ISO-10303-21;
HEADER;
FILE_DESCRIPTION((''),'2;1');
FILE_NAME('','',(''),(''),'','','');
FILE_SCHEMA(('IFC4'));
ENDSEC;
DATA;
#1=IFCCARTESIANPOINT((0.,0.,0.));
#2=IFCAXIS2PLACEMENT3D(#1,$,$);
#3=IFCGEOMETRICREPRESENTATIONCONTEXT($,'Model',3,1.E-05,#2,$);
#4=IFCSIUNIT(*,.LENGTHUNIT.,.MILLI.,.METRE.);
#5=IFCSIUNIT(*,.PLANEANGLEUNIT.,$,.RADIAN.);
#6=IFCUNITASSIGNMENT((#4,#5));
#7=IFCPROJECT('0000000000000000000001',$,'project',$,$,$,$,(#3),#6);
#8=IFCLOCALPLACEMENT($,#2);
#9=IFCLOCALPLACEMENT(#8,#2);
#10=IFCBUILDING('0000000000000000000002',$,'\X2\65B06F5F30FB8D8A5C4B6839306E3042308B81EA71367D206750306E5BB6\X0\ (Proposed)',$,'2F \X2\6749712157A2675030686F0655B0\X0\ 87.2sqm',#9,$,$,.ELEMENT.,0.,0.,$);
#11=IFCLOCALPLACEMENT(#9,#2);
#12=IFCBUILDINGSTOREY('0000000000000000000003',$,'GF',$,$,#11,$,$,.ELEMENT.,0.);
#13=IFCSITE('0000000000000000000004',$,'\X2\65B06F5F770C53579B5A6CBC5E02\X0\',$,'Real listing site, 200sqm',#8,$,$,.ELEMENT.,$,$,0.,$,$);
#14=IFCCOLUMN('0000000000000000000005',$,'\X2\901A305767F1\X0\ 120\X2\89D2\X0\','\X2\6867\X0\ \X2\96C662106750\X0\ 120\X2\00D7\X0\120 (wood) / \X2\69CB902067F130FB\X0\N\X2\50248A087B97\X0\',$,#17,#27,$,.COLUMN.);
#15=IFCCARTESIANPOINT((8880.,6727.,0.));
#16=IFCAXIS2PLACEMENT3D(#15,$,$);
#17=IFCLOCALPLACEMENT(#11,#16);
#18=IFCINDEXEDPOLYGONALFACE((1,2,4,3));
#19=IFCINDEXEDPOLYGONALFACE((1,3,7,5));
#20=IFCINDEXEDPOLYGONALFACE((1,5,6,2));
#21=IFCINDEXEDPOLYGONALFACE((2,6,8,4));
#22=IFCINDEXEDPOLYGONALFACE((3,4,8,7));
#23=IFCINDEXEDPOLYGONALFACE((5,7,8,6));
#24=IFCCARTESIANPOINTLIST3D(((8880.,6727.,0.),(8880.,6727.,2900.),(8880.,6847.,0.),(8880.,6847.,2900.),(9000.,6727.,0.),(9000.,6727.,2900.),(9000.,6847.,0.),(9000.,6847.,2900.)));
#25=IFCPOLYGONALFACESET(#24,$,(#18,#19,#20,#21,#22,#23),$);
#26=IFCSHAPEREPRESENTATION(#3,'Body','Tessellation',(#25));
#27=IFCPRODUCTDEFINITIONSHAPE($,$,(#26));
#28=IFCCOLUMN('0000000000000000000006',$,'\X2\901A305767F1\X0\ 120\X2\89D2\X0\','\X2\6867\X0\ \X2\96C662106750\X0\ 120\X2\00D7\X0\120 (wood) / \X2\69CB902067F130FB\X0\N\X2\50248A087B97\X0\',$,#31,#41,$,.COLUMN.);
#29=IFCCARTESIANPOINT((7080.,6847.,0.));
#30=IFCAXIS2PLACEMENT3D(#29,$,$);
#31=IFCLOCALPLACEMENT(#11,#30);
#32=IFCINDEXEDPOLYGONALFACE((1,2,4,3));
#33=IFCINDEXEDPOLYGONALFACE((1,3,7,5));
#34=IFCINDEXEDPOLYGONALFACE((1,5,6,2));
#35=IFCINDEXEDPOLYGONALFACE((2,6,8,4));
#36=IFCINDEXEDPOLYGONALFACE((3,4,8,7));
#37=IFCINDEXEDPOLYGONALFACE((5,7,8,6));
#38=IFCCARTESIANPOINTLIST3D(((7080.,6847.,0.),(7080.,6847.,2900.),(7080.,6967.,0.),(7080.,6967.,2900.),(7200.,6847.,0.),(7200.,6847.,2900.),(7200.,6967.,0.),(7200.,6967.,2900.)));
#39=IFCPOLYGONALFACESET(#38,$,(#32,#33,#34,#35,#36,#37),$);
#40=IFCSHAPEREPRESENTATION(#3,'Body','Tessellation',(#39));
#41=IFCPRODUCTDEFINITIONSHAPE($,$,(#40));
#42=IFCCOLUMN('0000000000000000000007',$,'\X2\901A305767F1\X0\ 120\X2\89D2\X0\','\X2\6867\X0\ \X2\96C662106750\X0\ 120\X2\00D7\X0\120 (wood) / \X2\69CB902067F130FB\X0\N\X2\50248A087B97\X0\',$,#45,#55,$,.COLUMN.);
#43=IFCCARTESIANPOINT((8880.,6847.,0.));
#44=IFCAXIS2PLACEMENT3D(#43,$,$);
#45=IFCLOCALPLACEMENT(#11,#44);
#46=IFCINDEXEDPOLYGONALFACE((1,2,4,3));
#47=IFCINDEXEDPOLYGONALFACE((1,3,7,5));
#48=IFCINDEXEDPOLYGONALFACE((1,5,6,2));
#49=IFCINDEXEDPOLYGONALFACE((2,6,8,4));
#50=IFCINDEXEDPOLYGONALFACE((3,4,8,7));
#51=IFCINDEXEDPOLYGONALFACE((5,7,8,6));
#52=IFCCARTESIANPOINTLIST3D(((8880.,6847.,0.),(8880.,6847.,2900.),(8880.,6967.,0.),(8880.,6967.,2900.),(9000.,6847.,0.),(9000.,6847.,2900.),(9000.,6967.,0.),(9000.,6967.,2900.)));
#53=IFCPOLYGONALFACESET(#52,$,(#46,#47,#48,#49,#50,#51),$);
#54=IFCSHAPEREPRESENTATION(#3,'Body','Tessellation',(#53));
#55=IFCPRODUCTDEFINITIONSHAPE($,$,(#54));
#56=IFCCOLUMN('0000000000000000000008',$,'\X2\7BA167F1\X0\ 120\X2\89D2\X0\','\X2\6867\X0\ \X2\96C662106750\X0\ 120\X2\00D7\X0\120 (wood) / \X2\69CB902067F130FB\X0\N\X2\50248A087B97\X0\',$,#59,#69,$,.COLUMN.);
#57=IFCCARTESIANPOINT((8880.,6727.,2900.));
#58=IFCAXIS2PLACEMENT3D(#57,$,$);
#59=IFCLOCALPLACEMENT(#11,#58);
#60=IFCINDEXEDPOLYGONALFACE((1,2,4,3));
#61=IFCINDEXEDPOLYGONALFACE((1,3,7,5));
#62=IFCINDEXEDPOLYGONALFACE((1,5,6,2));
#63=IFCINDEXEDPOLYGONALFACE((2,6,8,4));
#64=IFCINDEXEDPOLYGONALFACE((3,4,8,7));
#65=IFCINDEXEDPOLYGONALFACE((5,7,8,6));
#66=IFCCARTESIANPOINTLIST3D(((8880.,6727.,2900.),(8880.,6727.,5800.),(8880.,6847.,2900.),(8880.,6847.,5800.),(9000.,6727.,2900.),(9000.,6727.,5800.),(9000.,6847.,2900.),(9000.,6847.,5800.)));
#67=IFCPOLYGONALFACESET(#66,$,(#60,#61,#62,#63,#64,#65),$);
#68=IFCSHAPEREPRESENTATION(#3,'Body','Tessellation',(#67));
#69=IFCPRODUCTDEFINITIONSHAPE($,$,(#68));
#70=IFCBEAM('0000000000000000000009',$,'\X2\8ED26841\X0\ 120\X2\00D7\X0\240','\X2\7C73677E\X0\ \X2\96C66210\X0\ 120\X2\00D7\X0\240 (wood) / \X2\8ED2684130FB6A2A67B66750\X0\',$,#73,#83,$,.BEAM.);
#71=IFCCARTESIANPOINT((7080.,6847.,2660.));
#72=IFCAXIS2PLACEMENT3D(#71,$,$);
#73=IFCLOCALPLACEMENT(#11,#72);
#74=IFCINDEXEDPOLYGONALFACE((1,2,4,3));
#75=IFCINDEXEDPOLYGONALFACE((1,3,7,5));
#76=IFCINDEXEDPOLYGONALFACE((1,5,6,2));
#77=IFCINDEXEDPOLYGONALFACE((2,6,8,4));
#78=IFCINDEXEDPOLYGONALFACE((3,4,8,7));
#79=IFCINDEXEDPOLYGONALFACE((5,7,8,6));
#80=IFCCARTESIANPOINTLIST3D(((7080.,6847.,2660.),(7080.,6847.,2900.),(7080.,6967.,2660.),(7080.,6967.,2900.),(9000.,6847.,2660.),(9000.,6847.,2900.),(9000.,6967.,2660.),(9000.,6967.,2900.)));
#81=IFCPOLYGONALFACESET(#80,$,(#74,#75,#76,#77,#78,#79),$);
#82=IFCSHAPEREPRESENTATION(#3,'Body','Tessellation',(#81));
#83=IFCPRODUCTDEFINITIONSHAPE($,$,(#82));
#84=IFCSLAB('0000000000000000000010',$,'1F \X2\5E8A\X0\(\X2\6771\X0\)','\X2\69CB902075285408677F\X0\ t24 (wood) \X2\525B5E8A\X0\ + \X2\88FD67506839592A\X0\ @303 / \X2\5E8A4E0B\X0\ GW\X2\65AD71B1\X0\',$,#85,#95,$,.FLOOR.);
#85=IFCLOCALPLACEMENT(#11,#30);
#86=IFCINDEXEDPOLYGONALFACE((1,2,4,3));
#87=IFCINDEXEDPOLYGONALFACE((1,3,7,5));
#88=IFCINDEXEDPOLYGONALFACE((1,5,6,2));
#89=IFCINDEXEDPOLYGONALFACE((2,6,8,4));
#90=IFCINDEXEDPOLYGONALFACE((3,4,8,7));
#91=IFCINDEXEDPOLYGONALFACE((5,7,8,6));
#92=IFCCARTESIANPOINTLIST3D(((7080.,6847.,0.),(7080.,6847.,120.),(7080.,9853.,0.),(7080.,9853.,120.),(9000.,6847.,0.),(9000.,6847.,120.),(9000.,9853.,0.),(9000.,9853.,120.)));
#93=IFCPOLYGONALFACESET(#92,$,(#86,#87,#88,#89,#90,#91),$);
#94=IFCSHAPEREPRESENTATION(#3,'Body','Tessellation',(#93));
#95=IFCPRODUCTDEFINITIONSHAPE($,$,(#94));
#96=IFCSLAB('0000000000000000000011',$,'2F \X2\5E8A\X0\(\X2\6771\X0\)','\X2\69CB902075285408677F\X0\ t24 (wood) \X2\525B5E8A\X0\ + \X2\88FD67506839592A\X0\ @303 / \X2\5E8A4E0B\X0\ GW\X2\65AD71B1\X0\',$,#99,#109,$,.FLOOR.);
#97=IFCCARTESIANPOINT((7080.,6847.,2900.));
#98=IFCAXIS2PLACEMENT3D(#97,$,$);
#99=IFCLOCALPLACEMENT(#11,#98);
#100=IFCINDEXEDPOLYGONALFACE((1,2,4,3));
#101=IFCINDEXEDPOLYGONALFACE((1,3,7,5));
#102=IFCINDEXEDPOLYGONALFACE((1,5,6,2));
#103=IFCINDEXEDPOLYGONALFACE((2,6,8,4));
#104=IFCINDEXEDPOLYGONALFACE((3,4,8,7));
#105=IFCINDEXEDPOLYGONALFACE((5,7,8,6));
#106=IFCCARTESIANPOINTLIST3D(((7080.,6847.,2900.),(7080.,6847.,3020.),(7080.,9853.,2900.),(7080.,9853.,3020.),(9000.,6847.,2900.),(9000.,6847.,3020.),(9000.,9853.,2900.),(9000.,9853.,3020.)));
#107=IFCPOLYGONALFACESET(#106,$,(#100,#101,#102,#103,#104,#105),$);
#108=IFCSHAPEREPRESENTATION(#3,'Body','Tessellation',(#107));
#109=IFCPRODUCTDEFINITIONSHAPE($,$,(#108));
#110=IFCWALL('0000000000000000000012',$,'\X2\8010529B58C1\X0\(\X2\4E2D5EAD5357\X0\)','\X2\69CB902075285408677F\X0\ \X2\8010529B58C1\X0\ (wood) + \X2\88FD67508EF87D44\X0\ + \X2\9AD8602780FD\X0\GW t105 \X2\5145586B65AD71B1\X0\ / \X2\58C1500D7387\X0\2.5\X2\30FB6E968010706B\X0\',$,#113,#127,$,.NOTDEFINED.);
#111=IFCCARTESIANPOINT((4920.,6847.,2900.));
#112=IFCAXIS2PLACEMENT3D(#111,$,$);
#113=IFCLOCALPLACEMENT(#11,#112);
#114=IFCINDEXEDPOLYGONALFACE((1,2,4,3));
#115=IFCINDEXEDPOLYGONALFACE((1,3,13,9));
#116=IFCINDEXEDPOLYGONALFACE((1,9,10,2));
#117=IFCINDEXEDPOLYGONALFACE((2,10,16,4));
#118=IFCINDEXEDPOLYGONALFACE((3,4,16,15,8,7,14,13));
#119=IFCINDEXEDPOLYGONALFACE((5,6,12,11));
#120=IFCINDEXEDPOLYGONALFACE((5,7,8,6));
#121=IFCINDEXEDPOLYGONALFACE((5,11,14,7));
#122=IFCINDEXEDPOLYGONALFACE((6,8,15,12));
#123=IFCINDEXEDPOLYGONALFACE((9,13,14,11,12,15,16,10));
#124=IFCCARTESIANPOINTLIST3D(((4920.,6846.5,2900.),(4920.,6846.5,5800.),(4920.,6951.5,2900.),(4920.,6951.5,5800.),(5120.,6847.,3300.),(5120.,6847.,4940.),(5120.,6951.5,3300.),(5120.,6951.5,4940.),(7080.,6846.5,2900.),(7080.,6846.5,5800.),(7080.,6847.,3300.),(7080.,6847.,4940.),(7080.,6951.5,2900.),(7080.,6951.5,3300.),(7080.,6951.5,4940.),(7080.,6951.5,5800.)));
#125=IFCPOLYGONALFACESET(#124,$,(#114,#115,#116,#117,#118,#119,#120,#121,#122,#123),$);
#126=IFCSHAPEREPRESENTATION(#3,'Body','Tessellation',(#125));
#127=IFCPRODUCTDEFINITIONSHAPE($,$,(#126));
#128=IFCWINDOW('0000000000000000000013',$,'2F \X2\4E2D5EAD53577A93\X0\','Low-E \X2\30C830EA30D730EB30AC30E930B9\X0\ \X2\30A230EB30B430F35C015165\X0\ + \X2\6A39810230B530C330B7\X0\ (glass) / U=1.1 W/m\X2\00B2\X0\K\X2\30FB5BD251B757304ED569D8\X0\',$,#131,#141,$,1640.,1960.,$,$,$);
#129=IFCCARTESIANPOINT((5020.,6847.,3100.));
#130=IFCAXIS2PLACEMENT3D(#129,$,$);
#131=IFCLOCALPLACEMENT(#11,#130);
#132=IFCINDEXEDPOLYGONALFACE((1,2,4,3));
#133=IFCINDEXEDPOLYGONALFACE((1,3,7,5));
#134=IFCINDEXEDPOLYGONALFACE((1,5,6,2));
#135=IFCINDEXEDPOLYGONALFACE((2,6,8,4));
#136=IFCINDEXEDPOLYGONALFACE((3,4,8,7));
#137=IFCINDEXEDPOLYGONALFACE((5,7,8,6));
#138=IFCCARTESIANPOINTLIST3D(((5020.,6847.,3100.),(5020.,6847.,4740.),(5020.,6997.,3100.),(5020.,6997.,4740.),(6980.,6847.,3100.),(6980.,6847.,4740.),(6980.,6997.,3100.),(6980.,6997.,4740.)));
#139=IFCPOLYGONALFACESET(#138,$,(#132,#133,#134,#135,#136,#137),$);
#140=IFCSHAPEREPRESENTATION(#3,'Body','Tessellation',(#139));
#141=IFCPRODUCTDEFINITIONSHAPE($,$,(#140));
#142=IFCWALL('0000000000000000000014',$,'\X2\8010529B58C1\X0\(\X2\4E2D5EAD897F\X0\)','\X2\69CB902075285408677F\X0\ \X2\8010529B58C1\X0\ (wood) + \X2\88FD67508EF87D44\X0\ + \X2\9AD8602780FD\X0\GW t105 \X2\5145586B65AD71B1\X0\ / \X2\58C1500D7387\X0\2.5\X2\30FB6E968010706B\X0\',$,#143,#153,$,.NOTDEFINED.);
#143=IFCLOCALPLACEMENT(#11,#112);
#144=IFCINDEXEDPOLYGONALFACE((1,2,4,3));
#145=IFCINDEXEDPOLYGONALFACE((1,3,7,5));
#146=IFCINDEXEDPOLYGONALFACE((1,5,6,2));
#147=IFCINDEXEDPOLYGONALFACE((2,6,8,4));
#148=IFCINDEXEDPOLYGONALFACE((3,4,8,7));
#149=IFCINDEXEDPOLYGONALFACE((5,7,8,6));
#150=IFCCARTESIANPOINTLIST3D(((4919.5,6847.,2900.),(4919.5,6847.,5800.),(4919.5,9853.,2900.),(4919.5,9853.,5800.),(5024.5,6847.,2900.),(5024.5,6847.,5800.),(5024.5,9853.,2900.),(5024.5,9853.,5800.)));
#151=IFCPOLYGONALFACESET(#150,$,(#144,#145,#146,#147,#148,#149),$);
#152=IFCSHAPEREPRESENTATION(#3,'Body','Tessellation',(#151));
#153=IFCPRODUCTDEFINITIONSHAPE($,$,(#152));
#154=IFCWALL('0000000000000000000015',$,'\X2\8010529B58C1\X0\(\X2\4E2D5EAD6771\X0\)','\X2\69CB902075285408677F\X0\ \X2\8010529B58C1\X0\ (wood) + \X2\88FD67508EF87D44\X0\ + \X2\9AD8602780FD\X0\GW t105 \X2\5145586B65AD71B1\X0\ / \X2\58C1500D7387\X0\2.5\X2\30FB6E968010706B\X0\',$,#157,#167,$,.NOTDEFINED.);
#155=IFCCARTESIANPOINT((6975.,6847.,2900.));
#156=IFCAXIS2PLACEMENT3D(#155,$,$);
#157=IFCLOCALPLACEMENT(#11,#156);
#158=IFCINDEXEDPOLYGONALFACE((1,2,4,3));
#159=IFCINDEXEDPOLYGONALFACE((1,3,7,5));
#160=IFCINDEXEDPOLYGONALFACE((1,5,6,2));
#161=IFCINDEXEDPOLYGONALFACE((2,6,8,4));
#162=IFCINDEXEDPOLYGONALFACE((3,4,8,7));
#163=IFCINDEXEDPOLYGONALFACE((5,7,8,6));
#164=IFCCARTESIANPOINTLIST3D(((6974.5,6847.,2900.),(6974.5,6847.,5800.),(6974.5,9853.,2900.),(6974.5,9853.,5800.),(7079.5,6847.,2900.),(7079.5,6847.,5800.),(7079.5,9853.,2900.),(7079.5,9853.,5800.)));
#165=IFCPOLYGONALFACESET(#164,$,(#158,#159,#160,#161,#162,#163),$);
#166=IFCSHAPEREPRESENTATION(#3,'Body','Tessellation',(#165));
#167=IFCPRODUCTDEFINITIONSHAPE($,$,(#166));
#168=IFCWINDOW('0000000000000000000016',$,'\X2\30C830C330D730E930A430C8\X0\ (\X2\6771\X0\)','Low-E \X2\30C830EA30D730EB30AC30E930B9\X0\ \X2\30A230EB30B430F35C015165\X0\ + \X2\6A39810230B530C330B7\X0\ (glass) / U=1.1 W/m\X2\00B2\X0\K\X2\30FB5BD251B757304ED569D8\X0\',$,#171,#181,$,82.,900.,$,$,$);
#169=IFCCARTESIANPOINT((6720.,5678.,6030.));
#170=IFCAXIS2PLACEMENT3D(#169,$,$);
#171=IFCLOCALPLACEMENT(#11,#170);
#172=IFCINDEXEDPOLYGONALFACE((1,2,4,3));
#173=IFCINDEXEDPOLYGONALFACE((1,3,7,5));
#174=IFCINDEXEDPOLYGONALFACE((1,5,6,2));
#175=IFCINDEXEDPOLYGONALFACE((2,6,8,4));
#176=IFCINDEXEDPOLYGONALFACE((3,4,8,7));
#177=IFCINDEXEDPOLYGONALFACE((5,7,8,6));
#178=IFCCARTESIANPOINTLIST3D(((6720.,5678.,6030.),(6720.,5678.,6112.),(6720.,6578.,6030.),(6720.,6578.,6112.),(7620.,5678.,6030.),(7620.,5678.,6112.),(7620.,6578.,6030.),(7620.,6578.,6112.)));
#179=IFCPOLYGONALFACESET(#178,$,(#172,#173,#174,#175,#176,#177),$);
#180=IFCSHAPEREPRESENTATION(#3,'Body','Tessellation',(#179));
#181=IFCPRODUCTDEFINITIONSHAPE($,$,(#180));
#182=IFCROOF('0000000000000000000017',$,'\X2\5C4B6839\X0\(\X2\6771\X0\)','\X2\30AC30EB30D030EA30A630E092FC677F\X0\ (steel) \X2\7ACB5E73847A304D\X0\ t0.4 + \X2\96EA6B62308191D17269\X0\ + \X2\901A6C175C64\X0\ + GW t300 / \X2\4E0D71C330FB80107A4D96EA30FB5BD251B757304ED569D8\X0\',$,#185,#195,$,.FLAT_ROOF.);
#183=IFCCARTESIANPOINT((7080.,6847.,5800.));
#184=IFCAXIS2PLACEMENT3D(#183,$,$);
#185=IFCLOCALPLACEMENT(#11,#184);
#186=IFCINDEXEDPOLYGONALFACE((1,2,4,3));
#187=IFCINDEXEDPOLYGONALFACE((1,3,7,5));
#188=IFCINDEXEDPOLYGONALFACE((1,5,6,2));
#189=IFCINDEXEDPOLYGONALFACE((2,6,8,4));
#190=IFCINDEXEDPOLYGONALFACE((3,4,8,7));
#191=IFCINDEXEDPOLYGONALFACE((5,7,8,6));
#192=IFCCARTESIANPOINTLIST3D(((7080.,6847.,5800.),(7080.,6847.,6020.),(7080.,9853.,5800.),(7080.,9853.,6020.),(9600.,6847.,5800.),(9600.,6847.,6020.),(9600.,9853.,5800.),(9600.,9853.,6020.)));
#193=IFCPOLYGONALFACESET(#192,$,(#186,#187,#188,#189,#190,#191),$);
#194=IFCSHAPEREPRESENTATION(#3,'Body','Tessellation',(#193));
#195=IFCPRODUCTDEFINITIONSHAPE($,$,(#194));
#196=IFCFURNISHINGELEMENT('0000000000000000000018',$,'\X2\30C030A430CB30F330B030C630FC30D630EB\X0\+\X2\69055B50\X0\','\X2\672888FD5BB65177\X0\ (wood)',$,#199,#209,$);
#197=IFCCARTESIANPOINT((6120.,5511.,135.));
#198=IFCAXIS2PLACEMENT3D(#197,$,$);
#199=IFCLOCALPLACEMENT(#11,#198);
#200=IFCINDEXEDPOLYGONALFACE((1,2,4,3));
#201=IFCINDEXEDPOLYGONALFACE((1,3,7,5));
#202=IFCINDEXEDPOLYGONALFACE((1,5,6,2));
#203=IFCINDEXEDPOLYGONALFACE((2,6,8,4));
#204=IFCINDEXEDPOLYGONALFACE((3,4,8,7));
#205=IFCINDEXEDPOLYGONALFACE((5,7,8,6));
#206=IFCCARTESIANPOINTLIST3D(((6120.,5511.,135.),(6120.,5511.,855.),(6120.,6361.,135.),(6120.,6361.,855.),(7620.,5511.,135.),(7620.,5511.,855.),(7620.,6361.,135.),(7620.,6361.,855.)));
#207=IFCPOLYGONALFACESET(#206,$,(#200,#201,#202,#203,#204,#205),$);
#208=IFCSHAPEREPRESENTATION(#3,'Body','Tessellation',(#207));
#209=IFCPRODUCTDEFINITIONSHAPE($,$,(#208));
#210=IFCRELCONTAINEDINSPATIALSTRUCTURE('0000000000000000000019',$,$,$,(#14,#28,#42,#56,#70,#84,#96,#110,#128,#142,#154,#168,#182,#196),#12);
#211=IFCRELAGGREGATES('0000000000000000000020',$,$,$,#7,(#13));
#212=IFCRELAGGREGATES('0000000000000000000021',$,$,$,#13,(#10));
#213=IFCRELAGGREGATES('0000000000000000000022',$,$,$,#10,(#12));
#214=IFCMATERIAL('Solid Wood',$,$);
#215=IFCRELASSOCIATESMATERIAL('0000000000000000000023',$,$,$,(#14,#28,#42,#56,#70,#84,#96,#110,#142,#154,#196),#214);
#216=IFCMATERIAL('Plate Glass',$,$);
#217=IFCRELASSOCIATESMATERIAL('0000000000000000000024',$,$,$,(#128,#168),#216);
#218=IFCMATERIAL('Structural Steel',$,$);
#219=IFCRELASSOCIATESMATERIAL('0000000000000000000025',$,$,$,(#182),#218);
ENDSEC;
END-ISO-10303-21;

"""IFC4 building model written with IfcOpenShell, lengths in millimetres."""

from ifc_helpers import new_model, si_unit, frame, frame_2d, origin, place, context, project, spatial, rectangle, extrude, material, element, fill, save


model = new_model("IFC4")

# Units and contexts
model_context = context("Model", 3, precision=1e-05, world=origin())
ifc_project = project(units=[si_unit("LENGTHUNIT", "METRE", prefix="MILLI"), si_unit("PLANEANGLEUNIT", "RADIAN")], contexts=[model_context])

# Site, building, storey
site_placement = place(None, origin())
site = spatial("IfcSite", under=ifc_project, at=site_placement, Name="新潟県南魚沼市", ObjectType="Real listing site, 200sqm", CompositionType="ELEMENT", RefElevation=0.0)
building_placement = place(site_placement, origin())
building = spatial("IfcBuilding", under=site, at=building_placement, Name="新潟・越屋根のある自然素材の家 (Proposed)", ObjectType="2F 杉無垢材と漆喰 87.2sqm", CompositionType="ELEMENT", ElevationOfRefHeight=0.0, ElevationOfTerrain=0.0)
storey_placement = place(building_placement, origin())
storey = spatial("IfcBuildingStorey", under=building, at=storey_placement, Name="GF", CompositionType="ELEMENT", Elevation=0.0)

# Columns
ifc_material_1 = material(Name="Solid Wood")
column_1_placement = place(storey_placement, frame((8880.0, 6727.0, 0.0)))
element("IfcColumn", 1, at=column_1_placement, inside=storey, material=ifc_material_1, Name="通し柱 120角", Description="桧 集成材 120×120 (wood) / 構造柱・N値計算", PredefinedType="COLUMN", context=model_context, shape_type="SweptSolid", body=[
    extrude(rectangle(XDim=120.0, YDim=120.0, at=frame_2d((60.0, 60.0))), frame((8880.0, 6727.0, 0.0)), (0.0, 0.0, 1.0), 2900.0),
])
column_2_placement = place(storey_placement, frame((7080.0, 6847.0, 0.0)))
element("IfcColumn", 2, at=column_2_placement, inside=storey, material=ifc_material_1, Name="通し柱 120角", Description="桧 集成材 120×120 (wood) / 構造柱・N値計算", PredefinedType="COLUMN", context=model_context, shape_type="SweptSolid", body=[
    extrude(rectangle(XDim=120.0, YDim=120.0, at=frame_2d((60.0, 60.0))), frame((7080.0, 6847.0, 0.0)), (0.0, 0.0, 1.0), 2900.0),
])
column_3_placement = place(storey_placement, frame((8880.0, 6847.0, 0.0)))
element("IfcColumn", 3, at=column_3_placement, inside=storey, material=ifc_material_1, Name="通し柱 120角", Description="桧 集成材 120×120 (wood) / 構造柱・N値計算", PredefinedType="COLUMN", context=model_context, shape_type="SweptSolid", body=[
    extrude(rectangle(XDim=120.0, YDim=120.0, at=frame_2d((60.0, 60.0))), frame((8880.0, 6847.0, 0.0)), (0.0, 0.0, 1.0), 2900.0),
])
column_4_placement = place(storey_placement, frame((8880.0, 6727.0, 2900.0)))
element("IfcColumn", 4, at=column_4_placement, inside=storey, material=ifc_material_1, Name="管柱 120角", Description="桧 集成材 120×120 (wood) / 構造柱・N値計算", PredefinedType="COLUMN", context=model_context, shape_type="SweptSolid", body=[
    extrude(rectangle(XDim=120.0, YDim=120.0, at=frame_2d((60.0, 60.0))), frame((8880.0, 6727.0, 2900.0)), (0.0, 0.0, 1.0), 2900.0),
])

# Beam
beam_1_placement = place(storey_placement, frame((7080.0, 6847.0, 2660.0)))
element("IfcBeam", 5, at=beam_1_placement, inside=storey, material=ifc_material_1, Name="軒桁 120×240", Description="米松 集成 120×240 (wood) / 軒桁・横架材", PredefinedType="BEAM", context=model_context, shape_type="SweptSolid", body=[
    extrude(rectangle(XDim=1920.0, YDim=120.0, at=frame_2d((960.0, 60.0))), frame((7080.0, 6847.0, 2660.0)), (0.0, 0.0, 1.0), 240.0),
])

# Slabs
slab_1_placement = place(storey_placement, frame((7080.0, 6847.0, 0.0)))
element("IfcSlab", 6, at=slab_1_placement, inside=storey, material=ifc_material_1, Name="1F 床(東)", Description="構造用合板 t24 (wood) 剛床 + 製材根太 @303 / 床下 GW断熱", PredefinedType="FLOOR", context=model_context, shape_type="SweptSolid", body=[
    extrude(rectangle(XDim=1920.0, YDim=3006.0, at=frame_2d((960.0, 1503.0))), frame((7080.0, 6847.0, 0.0)), (0.0, 0.0, 1.0), 120.0),
])
slab_2_placement = place(storey_placement, frame((7080.0, 6847.0, 2900.0)))
element("IfcSlab", 7, at=slab_2_placement, inside=storey, material=ifc_material_1, Name="2F 床(東)", Description="構造用合板 t24 (wood) 剛床 + 製材根太 @303 / 床下 GW断熱", PredefinedType="FLOOR", context=model_context, shape_type="SweptSolid", body=[
    extrude(rectangle(XDim=1920.0, YDim=3006.0, at=frame_2d((960.0, 1503.0))), frame((7080.0, 6847.0, 2900.0)), (0.0, 0.0, 1.0), 120.0),
])

# Wall, opening, window
wall_1_placement = place(storey_placement, frame((4920.0, 6847.0, 2900.0)))
wall_1 = element("IfcWall", 8, at=wall_1_placement, inside=storey, material=ifc_material_1, Name="耐力壁(中庭南)", Description="構造用合板 耐力壁 (wood) + 製材軸組 + 高性能GW t105 充填断熱 / 壁倍率2.5・準耐火", PredefinedType="NOTDEFINED", context=model_context, shape_type="SweptSolid", body=[
    extrude(rectangle(XDim=2160.0, YDim=105.0, at=frame_2d((1080.0, 52.0))), frame((4920.0, 6847.0, 2900.0)), (0.0, 0.0, 1.0), 2900.0),
])
opening_placement = place(storey_placement, frame((5020.0, 6847.0, 3100.0)))
opening = element("IfcOpeningElement", 9, at=opening_placement, cuts=wall_1, PredefinedType="NOTDEFINED", context=model_context, shape_type="SweptSolid", body=[
    extrude(rectangle(XDim=1960.0, YDim=150.0, at=frame_2d((980.0, 75.0))), frame((5020.0, 6847.0, 3100.0)), (0.0, 0.0, 1.0), 1640.0),
])
ifc_material_2 = material(Name="Plate Glass")
window_1_placement = place(storey_placement, frame((5020.0, 6847.0, 3100.0)))
window_1 = element("IfcWindow", 10, at=window_1_placement, inside=storey, material=ifc_material_2, Name="2F 中庭南窓", Description="Low-E トリプルガラス アルゴン封入 + 樹脂サッシ (glass) / U=1.1 W/m²K・寒冷地仕様", OverallHeight=1640.0, OverallWidth=1960.0, context=model_context, shape_type="SweptSolid", body=[
    extrude(rectangle(XDim=1960.0, YDim=150.0, at=frame_2d((980.0, 75.0))), frame((5020.0, 6847.0, 3100.0)), (0.0, 0.0, 1.0), 1640.0),
])
fill(opening, window_1)

# Walls
wall_2_placement = place(storey_placement, frame((4920.0, 6847.0, 2900.0)))
element("IfcWall", 11, at=wall_2_placement, inside=storey, material=ifc_material_1, Name="耐力壁(中庭西)", Description="構造用合板 耐力壁 (wood) + 製材軸組 + 高性能GW t105 充填断熱 / 壁倍率2.5・準耐火", PredefinedType="NOTDEFINED", context=model_context, shape_type="SweptSolid", body=[
    extrude(rectangle(XDim=105.0, YDim=3006.0, at=frame_2d((52.0, 1503.0))), frame((4920.0, 6847.0, 2900.0)), (0.0, 0.0, 1.0), 2900.0),
])
wall_3_placement = place(storey_placement, frame((6975.0, 6847.0, 2900.0)))
element("IfcWall", 12, at=wall_3_placement, inside=storey, material=ifc_material_1, Name="耐力壁(中庭東)", Description="構造用合板 耐力壁 (wood) + 製材軸組 + 高性能GW t105 充填断熱 / 壁倍率2.5・準耐火", PredefinedType="NOTDEFINED", context=model_context, shape_type="SweptSolid", body=[
    extrude(rectangle(XDim=105.0, YDim=3006.0, at=frame_2d((52.0, 1503.0))), frame((6975.0, 6847.0, 2900.0)), (0.0, 0.0, 1.0), 2900.0),
])

# Window
window_2_placement = place(storey_placement, frame((6720.0, 5678.0, 6030.0)))
element("IfcWindow", 13, at=window_2_placement, inside=storey, material=ifc_material_2, Name="トップライト (東)", Description="Low-E トリプルガラス アルゴン封入 + 樹脂サッシ (glass) / U=1.1 W/m²K・寒冷地仕様", OverallHeight=82.0, OverallWidth=900.0, context=model_context, shape_type="SweptSolid", body=[
    extrude(rectangle(XDim=900.0, YDim=900.0, at=frame_2d((450.0, 450.0))), frame((6720.0, 5678.0, 6030.0)), (0.0, 0.0, 1.0), 82.0),
])

# Roof
ifc_material_3 = material(Name="Structural Steel")
for number, where, name in (
    (14, (7080.0, 6847.0, 5800.0), "屋根(東)"),
):
    element("IfcRoof", number, at=place(storey_placement, frame(where)), inside=storey, material=ifc_material_3, Name=name, Description="ガルバリウム鋼板 (steel) 立平葺き t0.4 + 雪止め金物 + 通気層 + GW t300 / 不燃・耐積雪・寒冷地仕様", PredefinedType="FLAT_ROOF", context=model_context, shape_type="SweptSolid", body=[
        extrude(rectangle(XDim=2520.0, YDim=3006.0, at=frame_2d((1260.0, 1503.0))), frame((7080.0, 6847.0, 5800.0)), (0.0, 0.0, 1.0), 220.0),
    ])

# Furnishing element
furnishing_1_placement = place(storey_placement, frame((6120.0, 5511.0, 135.0)))
element("IfcFurnishingElement", 15, at=furnishing_1_placement, inside=storey, material=ifc_material_1, Name="ダイニングテーブル+椅子", Description="木製家具 (wood)", context=model_context, shape_type="SweptSolid", body=[
    extrude(rectangle(XDim=1500.0, YDim=850.0, at=frame_2d((750.0, 425.0))), frame((6120.0, 5511.0, 135.0)), (0.0, 0.0, 1.0), 720.0),
])

save(model, "model.ifc")
